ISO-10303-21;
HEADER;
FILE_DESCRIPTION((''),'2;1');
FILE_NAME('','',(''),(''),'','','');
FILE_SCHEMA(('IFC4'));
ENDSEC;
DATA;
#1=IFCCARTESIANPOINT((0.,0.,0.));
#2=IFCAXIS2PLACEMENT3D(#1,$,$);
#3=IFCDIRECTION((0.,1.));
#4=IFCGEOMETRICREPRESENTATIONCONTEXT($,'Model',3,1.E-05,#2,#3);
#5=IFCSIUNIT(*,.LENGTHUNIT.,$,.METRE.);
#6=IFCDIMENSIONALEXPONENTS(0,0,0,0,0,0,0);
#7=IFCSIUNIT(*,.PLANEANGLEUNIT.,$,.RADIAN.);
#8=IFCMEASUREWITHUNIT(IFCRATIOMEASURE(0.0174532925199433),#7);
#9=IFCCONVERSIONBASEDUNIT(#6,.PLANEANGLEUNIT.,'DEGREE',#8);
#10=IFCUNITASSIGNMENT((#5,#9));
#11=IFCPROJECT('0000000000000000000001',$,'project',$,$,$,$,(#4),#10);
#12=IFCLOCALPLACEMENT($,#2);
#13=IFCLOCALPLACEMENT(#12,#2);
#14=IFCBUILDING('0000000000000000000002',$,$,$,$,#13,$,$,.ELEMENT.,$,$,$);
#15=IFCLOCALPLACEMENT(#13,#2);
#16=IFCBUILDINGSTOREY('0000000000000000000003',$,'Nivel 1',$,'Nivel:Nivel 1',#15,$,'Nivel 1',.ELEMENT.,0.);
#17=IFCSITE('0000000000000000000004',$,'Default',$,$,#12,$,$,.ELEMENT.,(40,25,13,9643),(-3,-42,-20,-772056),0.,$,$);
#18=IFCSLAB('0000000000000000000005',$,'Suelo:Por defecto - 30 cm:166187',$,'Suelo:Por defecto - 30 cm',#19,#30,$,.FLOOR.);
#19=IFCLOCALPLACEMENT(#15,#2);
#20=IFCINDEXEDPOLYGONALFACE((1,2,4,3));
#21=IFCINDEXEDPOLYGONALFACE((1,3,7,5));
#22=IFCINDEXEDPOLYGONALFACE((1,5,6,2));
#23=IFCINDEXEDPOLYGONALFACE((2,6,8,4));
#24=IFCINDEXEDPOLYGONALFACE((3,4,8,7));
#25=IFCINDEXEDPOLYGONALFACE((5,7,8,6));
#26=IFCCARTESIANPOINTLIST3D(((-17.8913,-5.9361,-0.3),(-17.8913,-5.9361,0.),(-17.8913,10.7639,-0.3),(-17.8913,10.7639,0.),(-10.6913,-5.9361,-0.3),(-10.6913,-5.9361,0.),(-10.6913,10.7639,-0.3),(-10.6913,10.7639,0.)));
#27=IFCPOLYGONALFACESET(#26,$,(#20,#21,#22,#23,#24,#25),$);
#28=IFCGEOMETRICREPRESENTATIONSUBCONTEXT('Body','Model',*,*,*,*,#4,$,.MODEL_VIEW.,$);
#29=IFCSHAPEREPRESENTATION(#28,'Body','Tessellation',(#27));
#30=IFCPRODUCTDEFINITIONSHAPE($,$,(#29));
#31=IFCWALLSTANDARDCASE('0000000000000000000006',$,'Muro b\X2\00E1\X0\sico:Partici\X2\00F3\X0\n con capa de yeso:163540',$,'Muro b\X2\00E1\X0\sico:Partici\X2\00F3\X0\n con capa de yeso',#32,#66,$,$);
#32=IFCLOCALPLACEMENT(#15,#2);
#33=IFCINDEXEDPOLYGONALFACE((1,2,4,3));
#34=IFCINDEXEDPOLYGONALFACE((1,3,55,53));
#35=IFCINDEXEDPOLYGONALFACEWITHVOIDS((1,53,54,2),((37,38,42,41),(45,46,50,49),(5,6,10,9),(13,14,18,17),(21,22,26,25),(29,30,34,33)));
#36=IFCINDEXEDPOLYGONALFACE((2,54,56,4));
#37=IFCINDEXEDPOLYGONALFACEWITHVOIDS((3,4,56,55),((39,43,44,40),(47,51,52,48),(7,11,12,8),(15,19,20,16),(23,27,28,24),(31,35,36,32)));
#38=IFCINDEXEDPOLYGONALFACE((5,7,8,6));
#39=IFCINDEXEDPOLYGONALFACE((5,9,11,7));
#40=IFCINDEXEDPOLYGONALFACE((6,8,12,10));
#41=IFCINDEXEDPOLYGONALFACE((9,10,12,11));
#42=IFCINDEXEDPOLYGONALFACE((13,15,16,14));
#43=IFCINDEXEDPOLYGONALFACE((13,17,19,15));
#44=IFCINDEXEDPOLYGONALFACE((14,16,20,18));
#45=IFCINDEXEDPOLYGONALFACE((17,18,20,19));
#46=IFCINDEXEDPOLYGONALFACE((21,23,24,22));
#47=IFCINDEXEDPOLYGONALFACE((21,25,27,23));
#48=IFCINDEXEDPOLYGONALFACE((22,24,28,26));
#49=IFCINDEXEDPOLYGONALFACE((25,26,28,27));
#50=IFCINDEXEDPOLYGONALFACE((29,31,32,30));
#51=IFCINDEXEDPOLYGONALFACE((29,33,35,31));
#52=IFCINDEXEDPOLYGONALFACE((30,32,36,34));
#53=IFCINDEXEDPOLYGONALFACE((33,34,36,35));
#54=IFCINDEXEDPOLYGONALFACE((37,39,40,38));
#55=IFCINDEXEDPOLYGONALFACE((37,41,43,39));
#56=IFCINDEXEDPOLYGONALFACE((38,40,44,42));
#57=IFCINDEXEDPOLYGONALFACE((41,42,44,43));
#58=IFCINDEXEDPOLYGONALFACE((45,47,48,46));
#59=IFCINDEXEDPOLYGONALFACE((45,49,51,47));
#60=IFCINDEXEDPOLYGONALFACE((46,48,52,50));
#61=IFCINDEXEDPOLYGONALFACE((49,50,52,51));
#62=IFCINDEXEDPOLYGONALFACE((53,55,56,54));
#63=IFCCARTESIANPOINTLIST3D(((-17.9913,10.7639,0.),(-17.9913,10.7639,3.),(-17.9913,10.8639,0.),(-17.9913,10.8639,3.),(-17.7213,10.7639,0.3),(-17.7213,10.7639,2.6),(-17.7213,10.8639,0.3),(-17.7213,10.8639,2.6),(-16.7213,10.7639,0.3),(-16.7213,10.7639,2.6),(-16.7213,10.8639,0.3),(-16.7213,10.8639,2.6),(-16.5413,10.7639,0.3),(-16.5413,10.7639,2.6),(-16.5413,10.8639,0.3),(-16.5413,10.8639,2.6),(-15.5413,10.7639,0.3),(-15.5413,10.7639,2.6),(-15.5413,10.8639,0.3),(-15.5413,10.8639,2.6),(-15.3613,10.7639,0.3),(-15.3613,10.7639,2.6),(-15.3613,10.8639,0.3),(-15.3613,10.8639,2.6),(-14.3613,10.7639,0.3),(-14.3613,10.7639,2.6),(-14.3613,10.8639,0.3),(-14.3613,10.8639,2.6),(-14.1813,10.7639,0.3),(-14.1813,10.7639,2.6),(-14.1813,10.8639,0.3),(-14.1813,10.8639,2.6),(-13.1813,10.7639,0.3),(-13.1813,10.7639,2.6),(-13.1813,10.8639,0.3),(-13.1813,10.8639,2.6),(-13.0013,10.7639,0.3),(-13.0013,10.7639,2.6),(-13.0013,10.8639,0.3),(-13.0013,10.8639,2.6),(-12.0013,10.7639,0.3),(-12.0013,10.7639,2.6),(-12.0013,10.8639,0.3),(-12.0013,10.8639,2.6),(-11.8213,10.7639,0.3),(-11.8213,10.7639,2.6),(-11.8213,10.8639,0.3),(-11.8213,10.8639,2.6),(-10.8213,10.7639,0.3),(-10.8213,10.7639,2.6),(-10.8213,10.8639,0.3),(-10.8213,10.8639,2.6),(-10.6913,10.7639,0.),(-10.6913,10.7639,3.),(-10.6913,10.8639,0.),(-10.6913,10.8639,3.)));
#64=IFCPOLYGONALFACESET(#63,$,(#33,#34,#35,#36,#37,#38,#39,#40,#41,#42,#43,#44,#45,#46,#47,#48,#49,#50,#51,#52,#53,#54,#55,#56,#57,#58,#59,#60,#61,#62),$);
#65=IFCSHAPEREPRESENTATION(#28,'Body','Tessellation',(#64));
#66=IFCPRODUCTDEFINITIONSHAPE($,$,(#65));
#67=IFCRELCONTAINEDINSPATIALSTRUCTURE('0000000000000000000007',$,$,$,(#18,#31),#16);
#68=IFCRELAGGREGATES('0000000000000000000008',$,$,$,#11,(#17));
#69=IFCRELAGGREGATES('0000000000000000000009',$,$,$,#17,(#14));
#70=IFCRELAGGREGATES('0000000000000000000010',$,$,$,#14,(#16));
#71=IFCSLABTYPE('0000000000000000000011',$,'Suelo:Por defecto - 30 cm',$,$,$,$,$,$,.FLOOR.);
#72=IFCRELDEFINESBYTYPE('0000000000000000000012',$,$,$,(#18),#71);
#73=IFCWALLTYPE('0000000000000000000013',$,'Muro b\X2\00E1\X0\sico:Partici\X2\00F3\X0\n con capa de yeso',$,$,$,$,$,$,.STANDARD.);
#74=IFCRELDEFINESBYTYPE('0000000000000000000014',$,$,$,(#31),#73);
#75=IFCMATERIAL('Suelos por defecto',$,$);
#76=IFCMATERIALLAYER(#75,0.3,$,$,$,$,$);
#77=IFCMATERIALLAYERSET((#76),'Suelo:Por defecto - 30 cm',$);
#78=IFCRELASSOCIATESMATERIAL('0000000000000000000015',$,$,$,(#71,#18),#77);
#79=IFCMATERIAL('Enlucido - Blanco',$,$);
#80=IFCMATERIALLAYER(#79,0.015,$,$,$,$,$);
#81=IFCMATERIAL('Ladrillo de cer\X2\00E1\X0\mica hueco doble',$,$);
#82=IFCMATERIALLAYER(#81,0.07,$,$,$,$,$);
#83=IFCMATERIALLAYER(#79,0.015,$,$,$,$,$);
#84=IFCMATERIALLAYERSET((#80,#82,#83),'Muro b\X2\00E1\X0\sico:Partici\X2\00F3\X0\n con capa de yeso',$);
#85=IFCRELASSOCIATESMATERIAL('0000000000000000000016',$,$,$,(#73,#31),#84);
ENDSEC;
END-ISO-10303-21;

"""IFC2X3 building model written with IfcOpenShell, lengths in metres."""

from ifc_helpers import new_model, entity, si_unit, converted_unit, direction, frame, frame_2d, origin, origin_2d_with_axis, place, context, subcontext, project, spatial, rectangle, extrude, material, layer, layer_set, layer_usage, type_object, element, save


model = new_model("IFC2X3")

# Units and contexts
model_context = context("Model", 3, precision=1e-05, world=origin(), true_north=direction((0.0, 1.0)))
body_context = subcontext(model_context, "Body", "Model", "MODEL_VIEW")
ifc_project = project(units=[si_unit("LENGTHUNIT", "METRE"), converted_unit("PLANEANGLEUNIT", "DEGREE", entity("IfcRatioMeasure", 0.0174532925199433), si_unit("PLANEANGLEUNIT", "RADIAN"), dimensions=[0, 0, 0, 0, 0, 0, 0])], contexts=[model_context])

# Site, building, storey
site_placement = place(None, origin())
site = spatial("IfcSite", under=ifc_project, at=site_placement, Name="Default", CompositionType="ELEMENT", RefLatitude=(40, 25, 13, 9643), RefLongitude=(-3, -42, -20, -772056), RefElevation=0.0)
building_placement = place(site_placement, origin())
building = spatial("IfcBuilding", under=site, at=building_placement, CompositionType="ELEMENT")
storey_placement = place(building_placement, origin())
storey = spatial("IfcBuildingStorey", under=building, at=storey_placement, Name="Nivel 1", ObjectType="Nivel:Nivel 1", LongName="Nivel 1", CompositionType="ELEMENT", Elevation=0.0)

# Slab
ifc_material_1 = material(Name="Suelos por defecto")
ifc_layer_1 = layer(ifc_material_1, 0.3)
ifc_layer_set_1 = layer_set([ifc_layer_1], Name="Suelo:Por defecto - 30 cm")
ifc_layer_usage_1 = layer_usage(ifc_layer_set_1, "AXIS3", "POSITIVE", 0.0)
slab_type = type_object("IfcSlabType", Name="Suelo:Por defecto - 30 cm", PredefinedType="FLOOR", material=ifc_layer_set_1)
slab_placement = place(storey_placement, origin())
element("IfcSlab", 1, at=slab_placement, inside=storey, type_object=slab_type, material=ifc_layer_usage_1, Name="Suelo:Por defecto - 30 cm:166187", ObjectType="Suelo:Por defecto - 30 cm", PredefinedType="FLOOR", context=body_context, shape_type="SweptSolid", body=[
    extrude(rectangle(XDim=16.7, YDim=7.2, at=origin_2d_with_axis()), frame((-14.2913, 2.4139, 0.0), z_axis=(0.0, 0.0, -1.0), x_axis=(0.0, 1.0, 0.0)), (0.0, 0.0, 1.0), 0.3),
])

# Wall, openings
ifc_material_2 = material(Name="Enlucido - Blanco")
ifc_layer_2 = layer(ifc_material_2, 0.015)
ifc_material_3 = material(Name="Ladrillo de cerámica hueco doble")
ifc_layer_3 = layer(ifc_material_3, 0.07)
ifc_layer_4 = layer(ifc_material_2, 0.015)
ifc_layer_set_2 = layer_set([ifc_layer_2, ifc_layer_3, ifc_layer_4], Name="Muro básico:Partición con capa de yeso")
ifc_layer_usage_2 = layer_usage(ifc_layer_set_2, "AXIS2", "NEGATIVE", 0.05)
wall_type = type_object("IfcWallType", Name="Muro básico:Partición con capa de yeso", PredefinedType="STANDARD", material=ifc_layer_set_2)
wall_1_placement = place(storey_placement, frame((-17.9913, 10.8139, 0.0)))
wall_1 = element("IfcWallStandardCase", 2, at=wall_1_placement, inside=storey, type_object=wall_type, material=ifc_layer_usage_2, Name="Muro básico:Partición con capa de yeso:163540", ObjectType="Muro básico:Partición con capa de yeso", context=body_context, shape_type="SweptSolid", body=[
    extrude(rectangle(XDim=7.3, YDim=0.1, at=frame_2d((3.65, 0.0), x_axis=(-1.0, 0.0))), origin(), (0.0, 0.0, 1.0), 3.0),
])
opening_1_placement = place(wall_1_placement, frame((1.45, -0.05, 0.3)))
element("IfcOpeningElement", 3, at=opening_1_placement, cuts=wall_1, ObjectType="Opening", context=body_context, shape_type="SweptSolid", body=[
    extrude(rectangle(XDim=2.3, YDim=1.0, at=frame_2d((1.15, 0.5), x_axis=(1.0, 0.0))), frame((0.0, 0.0, 0.0), z_axis=(0.0, 1.0, 0.0), x_axis=(0.0, 0.0, 1.0)), (0.0, 0.0, 1.0), 0.1),
])
opening_2_placement = place(wall_1_placement, frame((0.27, -0.05, 0.3)))
element("IfcOpeningElement", 4, at=opening_2_placement, cuts=wall_1, ObjectType="Opening", context=body_context, shape_type="SweptSolid", body=[
    extrude(rectangle(XDim=2.3, YDim=1.0, at=frame_2d((1.15, 0.5), x_axis=(1.0, 0.0))), frame((0.0, 0.0, 0.0), z_axis=(0.0, 1.0, 0.0), x_axis=(0.0, 0.0, 1.0)), (0.0, 0.0, 1.0), 0.1),
])
opening_3_placement = place(wall_1_placement, frame((2.63, -0.05, 0.3)))
element("IfcOpeningElement", 5, at=opening_3_placement, cuts=wall_1, ObjectType="Opening", context=body_context, shape_type="SweptSolid", body=[
    extrude(rectangle(XDim=2.3, YDim=1.0, at=frame_2d((1.15, 0.5), x_axis=(1.0, 0.0))), frame((0.0, 0.0, 0.0), z_axis=(0.0, 1.0, 0.0), x_axis=(0.0, 0.0, 1.0)), (0.0, 0.0, 1.0), 0.1),
])
opening_4_placement = place(wall_1_placement, frame((3.81, -0.05, 0.3)))
element("IfcOpeningElement", 6, at=opening_4_placement, cuts=wall_1, ObjectType="Opening", context=body_context, shape_type="SweptSolid", body=[
    extrude(rectangle(XDim=2.3, YDim=1.0, at=frame_2d((1.15, 0.5), x_axis=(1.0, 0.0))), frame((0.0, 0.0, 0.0), z_axis=(0.0, 1.0, 0.0), x_axis=(0.0, 0.0, 1.0)), (0.0, 0.0, 1.0), 0.1),
])
opening_5_placement = place(wall_1_placement, frame((4.99, -0.05, 0.3)))
element("IfcOpeningElement", 7, at=opening_5_placement, cuts=wall_1, ObjectType="Opening", context=body_context, shape_type="SweptSolid", body=[
    extrude(rectangle(XDim=2.3, YDim=1.0, at=frame_2d((1.15, 0.5), x_axis=(1.0, 0.0))), frame((0.0, 0.0, 0.0), z_axis=(0.0, 1.0, 0.0), x_axis=(0.0, 0.0, 1.0)), (0.0, 0.0, 1.0), 0.1),
])
opening_6_placement = place(wall_1_placement, frame((6.17, -0.05, 0.3)))
element("IfcOpeningElement", 8, at=opening_6_placement, cuts=wall_1, ObjectType="Opening", context=body_context, shape_type="SweptSolid", body=[
    extrude(rectangle(XDim=2.3, YDim=1.0, at=frame_2d((1.15, 0.5), x_axis=(1.0, 0.0))), frame((0.0, 0.0, 0.0), z_axis=(0.0, 1.0, 0.0), x_axis=(0.0, 0.0, 1.0)), (0.0, 0.0, 1.0), 0.1),
])

save(model, "model.ifc")
